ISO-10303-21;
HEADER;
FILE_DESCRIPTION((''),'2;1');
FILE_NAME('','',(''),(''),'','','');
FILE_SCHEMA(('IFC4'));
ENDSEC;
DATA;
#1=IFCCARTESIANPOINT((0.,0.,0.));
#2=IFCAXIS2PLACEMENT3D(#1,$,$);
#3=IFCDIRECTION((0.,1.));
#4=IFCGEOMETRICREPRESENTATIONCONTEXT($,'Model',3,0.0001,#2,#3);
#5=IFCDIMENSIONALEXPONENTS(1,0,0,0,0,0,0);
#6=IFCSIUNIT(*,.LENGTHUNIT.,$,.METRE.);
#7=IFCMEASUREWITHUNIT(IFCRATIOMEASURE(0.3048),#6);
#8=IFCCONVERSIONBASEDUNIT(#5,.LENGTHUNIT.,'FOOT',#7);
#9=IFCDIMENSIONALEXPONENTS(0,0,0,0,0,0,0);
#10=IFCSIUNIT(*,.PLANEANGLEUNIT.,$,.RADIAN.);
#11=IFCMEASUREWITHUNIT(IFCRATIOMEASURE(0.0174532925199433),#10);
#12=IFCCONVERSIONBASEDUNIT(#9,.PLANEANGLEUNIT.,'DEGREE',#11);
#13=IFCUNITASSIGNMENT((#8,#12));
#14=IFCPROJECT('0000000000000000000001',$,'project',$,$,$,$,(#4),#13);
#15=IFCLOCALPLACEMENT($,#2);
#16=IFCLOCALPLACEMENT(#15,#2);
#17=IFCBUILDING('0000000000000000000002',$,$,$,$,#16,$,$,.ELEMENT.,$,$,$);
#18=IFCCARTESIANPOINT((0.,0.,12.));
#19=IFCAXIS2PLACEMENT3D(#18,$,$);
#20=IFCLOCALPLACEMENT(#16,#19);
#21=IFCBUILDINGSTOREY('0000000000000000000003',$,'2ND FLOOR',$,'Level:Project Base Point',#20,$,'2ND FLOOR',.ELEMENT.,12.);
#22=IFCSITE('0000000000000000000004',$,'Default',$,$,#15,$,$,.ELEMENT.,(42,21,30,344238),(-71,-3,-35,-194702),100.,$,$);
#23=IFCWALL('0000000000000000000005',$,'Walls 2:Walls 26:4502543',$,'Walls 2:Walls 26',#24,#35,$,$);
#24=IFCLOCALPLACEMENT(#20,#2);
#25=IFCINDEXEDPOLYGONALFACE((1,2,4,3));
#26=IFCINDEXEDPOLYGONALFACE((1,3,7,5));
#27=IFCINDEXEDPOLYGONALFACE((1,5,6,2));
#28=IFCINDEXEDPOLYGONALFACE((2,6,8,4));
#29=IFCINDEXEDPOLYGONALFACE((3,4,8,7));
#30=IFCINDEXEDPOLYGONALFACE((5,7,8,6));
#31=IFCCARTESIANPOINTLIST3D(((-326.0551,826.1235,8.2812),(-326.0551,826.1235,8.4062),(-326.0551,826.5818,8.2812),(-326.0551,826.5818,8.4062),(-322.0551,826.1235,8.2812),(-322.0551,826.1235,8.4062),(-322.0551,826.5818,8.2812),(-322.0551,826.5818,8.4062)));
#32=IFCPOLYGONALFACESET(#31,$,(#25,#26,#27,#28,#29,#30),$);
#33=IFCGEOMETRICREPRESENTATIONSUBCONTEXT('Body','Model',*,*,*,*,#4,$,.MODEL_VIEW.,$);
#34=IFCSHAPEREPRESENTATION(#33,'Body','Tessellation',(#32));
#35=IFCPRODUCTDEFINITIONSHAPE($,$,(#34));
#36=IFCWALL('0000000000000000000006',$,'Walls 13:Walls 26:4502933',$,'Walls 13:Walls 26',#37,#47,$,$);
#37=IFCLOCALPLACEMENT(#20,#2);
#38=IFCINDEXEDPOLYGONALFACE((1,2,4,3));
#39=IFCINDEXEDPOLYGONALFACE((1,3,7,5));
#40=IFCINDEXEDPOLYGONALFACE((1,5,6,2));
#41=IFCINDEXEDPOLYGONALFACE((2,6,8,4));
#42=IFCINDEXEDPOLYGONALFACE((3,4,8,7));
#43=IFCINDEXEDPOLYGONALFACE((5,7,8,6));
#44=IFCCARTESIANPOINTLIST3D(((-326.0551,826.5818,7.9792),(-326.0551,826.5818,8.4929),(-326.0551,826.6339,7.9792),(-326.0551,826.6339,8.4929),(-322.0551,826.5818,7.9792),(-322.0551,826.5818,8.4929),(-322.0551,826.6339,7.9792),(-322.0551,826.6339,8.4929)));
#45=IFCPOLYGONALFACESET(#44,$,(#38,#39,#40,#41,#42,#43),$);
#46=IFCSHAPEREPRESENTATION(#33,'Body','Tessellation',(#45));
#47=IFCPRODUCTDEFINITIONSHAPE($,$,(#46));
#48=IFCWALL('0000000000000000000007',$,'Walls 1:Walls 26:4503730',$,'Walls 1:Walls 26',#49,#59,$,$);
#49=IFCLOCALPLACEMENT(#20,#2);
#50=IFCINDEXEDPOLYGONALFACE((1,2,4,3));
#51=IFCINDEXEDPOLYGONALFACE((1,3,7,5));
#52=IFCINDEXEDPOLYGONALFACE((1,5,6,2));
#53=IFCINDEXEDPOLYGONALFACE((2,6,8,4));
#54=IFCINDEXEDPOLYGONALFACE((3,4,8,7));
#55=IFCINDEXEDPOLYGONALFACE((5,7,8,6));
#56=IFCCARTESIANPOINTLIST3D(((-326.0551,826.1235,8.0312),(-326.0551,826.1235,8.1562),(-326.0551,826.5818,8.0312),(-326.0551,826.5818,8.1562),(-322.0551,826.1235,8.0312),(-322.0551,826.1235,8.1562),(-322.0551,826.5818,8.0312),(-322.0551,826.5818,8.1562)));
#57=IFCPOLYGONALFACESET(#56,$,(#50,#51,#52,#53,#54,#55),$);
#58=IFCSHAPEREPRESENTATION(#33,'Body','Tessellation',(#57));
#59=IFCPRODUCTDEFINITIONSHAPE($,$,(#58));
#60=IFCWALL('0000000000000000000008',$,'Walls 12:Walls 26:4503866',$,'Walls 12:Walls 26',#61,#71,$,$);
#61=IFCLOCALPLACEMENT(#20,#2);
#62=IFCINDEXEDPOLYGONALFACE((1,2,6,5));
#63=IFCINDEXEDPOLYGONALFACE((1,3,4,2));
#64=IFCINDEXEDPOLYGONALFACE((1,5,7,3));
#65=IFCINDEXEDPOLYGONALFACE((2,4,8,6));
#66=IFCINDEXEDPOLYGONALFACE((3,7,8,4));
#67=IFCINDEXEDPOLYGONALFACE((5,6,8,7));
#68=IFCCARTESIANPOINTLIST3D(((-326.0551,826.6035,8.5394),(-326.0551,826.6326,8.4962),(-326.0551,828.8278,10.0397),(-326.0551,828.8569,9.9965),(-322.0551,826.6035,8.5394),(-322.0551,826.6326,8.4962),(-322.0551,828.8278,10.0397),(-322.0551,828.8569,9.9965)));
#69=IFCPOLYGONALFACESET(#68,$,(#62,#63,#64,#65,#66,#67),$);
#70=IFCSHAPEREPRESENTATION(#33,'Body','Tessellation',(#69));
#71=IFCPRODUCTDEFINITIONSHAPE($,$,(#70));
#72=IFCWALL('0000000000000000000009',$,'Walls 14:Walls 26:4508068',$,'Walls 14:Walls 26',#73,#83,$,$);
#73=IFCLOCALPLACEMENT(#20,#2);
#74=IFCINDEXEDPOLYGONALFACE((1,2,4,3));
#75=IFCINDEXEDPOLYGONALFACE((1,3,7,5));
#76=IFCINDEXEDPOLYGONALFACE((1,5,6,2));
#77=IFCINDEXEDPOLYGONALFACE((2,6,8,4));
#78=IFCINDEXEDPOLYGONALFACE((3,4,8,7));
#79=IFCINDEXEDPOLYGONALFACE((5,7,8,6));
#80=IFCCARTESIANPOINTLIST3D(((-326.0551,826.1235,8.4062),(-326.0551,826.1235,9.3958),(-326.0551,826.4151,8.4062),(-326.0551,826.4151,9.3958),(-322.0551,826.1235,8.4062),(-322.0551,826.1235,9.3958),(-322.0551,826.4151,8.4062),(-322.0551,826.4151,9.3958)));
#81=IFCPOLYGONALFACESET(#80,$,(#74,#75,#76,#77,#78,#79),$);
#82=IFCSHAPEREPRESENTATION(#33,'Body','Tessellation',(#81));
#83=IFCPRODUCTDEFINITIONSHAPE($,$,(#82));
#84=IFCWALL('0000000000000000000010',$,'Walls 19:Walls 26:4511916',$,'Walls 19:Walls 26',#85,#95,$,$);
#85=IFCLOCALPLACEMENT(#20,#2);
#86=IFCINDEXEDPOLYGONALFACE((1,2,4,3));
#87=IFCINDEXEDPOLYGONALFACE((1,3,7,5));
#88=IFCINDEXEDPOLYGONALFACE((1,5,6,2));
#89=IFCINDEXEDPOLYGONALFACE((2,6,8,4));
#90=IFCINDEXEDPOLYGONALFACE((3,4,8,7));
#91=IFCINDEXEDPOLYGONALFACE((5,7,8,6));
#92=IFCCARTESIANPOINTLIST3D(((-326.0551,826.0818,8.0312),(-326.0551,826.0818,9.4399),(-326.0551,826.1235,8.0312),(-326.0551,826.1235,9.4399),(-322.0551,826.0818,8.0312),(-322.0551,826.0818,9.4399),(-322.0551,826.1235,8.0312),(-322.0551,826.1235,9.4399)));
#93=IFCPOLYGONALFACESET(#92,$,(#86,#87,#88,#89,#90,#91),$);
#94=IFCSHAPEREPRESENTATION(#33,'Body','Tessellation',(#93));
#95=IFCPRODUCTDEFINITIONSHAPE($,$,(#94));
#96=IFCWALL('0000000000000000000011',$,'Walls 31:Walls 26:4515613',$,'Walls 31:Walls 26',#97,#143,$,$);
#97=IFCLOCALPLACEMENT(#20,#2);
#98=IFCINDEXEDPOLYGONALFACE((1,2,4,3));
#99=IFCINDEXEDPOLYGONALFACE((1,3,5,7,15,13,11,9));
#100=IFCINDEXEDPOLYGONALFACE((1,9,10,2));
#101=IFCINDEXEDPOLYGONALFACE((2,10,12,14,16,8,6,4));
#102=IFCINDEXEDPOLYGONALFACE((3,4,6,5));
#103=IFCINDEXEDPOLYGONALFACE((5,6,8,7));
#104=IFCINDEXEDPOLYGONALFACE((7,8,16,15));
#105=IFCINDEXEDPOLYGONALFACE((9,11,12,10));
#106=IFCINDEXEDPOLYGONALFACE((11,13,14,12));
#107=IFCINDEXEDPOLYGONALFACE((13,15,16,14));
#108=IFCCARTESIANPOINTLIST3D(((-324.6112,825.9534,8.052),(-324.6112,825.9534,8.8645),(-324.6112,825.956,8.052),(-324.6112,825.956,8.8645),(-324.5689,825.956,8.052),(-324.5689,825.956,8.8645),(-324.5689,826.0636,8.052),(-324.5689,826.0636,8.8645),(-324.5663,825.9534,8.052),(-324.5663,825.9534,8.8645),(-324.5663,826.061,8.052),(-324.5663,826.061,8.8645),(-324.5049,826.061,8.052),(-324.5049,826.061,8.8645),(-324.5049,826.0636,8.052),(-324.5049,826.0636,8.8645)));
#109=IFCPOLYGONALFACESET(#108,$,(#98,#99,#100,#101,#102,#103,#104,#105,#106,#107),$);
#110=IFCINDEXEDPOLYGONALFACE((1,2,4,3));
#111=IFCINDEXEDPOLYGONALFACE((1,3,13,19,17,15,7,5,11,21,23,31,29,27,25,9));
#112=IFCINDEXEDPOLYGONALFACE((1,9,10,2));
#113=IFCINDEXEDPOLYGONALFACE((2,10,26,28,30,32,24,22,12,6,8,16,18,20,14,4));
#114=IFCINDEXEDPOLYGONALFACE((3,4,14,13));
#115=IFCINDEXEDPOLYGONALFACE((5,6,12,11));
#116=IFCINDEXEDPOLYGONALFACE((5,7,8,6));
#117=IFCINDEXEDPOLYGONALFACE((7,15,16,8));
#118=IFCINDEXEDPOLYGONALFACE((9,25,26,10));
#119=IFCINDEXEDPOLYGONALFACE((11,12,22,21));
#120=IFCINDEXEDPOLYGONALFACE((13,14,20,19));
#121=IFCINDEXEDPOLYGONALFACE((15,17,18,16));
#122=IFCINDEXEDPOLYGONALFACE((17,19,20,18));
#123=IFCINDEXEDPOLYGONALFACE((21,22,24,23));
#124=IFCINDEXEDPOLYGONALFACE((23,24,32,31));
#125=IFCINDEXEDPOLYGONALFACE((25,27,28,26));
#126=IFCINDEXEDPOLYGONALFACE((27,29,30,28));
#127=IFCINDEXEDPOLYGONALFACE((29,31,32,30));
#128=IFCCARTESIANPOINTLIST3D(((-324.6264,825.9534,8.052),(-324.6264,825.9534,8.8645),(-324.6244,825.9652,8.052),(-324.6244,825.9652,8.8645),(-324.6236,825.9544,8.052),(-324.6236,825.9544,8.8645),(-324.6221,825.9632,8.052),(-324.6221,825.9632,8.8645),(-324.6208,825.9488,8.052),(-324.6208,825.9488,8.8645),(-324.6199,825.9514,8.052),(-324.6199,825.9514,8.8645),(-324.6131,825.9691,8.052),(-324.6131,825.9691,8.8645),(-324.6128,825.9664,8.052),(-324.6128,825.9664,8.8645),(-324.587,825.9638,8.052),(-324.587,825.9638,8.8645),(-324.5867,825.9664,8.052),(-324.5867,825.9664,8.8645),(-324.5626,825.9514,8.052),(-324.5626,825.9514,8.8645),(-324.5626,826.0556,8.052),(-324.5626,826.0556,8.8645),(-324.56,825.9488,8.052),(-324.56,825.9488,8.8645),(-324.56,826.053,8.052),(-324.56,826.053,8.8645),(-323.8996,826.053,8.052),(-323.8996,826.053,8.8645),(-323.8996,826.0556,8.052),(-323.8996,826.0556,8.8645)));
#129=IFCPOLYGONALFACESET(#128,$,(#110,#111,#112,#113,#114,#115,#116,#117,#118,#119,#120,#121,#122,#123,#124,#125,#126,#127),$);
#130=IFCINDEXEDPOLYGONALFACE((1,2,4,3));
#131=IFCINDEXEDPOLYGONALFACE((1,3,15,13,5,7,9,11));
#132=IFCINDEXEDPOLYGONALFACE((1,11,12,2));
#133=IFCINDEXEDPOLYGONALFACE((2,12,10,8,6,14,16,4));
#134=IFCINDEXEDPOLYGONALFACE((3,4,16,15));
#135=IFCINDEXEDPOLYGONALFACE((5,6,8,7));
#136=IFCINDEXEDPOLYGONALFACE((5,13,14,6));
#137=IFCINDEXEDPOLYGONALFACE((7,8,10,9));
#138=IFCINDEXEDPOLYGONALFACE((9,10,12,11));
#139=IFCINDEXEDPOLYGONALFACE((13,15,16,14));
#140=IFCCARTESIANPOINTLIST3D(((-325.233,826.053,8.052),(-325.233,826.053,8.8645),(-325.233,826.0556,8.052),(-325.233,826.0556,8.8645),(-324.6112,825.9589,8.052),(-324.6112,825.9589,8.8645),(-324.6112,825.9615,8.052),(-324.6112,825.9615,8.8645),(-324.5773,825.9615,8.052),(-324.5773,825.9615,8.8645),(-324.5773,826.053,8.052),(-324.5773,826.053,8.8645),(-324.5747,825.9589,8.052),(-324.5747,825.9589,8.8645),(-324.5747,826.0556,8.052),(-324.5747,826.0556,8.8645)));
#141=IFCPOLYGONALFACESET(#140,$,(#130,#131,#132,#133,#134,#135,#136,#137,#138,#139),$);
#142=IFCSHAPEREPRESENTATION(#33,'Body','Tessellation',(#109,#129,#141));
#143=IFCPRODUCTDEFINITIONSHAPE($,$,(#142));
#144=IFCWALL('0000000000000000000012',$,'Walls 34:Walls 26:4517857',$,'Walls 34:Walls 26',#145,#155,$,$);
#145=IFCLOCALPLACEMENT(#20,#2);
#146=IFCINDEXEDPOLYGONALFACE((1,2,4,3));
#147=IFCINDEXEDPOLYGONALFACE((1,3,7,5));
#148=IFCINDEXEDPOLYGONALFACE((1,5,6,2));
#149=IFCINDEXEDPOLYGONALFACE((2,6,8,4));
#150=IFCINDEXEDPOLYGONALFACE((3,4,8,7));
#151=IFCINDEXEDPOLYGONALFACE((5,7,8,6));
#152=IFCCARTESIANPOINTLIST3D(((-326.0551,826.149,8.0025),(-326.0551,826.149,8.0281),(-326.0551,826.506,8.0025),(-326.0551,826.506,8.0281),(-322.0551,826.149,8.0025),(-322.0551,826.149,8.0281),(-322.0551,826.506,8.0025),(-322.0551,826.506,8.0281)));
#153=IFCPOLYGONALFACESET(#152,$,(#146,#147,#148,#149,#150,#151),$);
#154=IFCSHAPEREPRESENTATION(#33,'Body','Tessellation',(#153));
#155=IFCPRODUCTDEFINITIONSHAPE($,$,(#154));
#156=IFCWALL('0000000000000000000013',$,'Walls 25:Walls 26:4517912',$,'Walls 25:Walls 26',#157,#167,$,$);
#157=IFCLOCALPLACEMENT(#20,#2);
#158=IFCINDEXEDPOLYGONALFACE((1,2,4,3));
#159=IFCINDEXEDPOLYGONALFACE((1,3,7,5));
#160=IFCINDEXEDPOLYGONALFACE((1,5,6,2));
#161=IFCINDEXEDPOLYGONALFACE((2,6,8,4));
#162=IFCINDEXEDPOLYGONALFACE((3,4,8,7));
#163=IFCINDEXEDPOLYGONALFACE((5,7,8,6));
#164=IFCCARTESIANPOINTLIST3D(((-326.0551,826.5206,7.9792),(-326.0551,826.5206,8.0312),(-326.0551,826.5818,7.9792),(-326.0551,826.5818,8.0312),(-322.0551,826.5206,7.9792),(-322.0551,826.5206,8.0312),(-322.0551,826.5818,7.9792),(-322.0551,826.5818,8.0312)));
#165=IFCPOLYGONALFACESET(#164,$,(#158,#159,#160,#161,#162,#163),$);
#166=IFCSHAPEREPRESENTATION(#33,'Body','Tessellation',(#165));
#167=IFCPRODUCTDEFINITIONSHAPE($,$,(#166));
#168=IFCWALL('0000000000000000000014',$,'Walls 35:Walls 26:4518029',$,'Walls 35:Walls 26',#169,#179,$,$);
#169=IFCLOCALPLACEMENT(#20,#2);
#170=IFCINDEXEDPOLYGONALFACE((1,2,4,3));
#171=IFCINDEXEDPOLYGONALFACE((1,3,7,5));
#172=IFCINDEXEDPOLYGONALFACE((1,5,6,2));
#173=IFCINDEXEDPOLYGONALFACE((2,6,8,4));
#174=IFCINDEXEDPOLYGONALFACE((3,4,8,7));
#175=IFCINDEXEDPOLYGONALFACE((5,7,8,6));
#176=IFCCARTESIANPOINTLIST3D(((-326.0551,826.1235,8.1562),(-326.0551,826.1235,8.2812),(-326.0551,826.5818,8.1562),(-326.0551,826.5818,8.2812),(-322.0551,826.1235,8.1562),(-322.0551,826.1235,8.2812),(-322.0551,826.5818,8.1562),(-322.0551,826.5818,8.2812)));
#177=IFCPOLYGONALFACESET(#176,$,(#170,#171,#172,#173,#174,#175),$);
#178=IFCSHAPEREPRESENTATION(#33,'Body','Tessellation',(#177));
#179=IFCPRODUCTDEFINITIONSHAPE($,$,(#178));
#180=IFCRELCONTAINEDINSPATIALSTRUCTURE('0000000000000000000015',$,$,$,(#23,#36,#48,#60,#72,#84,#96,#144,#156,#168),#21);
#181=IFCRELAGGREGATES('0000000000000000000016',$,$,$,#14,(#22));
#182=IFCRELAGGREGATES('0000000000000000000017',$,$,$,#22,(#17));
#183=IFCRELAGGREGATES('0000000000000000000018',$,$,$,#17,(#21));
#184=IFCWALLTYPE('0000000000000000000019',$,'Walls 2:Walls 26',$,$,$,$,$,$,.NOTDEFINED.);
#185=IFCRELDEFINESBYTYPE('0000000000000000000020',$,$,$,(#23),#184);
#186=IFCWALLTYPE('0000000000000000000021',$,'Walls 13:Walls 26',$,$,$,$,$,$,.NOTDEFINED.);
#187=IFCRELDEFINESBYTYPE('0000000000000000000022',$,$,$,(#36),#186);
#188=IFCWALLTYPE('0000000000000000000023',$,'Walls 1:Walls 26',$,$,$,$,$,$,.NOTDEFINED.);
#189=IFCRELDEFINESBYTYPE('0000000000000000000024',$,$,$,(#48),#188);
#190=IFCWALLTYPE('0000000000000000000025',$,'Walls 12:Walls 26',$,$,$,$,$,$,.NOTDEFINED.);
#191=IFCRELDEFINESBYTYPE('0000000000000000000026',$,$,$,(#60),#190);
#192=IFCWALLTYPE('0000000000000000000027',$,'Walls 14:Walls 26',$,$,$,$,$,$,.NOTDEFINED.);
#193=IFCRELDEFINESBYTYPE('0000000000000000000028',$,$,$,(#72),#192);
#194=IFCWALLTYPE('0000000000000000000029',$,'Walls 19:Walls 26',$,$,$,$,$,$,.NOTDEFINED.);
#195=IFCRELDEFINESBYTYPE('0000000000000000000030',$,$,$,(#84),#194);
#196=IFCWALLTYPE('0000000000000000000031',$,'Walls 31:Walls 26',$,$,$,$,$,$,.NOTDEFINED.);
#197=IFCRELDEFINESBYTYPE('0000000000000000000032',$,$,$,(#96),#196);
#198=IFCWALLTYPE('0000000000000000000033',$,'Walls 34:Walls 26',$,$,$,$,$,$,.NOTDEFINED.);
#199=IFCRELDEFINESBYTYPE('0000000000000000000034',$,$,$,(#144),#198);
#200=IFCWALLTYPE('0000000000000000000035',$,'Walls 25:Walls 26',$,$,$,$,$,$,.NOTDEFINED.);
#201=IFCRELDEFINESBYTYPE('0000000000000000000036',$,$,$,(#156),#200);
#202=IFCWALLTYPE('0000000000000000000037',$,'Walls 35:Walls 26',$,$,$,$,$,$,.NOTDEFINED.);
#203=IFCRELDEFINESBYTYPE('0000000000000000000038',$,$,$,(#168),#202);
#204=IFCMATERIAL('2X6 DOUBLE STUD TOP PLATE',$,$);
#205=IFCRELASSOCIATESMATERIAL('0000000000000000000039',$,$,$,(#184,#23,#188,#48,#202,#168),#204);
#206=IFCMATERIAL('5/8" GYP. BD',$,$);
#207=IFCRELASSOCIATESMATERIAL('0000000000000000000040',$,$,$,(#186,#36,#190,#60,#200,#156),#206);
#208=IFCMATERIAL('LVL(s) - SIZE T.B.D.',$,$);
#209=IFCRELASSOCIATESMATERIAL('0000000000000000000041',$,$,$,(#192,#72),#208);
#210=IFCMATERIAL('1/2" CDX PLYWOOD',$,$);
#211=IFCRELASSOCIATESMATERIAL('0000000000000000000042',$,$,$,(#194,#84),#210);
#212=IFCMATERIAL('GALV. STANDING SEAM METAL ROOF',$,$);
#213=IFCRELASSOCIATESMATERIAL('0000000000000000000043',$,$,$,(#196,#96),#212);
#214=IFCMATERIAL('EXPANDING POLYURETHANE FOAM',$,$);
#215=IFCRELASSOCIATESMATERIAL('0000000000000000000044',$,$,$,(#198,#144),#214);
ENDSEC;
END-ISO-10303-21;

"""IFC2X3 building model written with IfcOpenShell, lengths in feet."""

from ifc_helpers import new_model, entity, si_unit, converted_unit, direction, frame, frame_2d, origin, origin_2d_with_axis, place, context, subcontext, project, spatial, polyline, rectangle, outline, extrude, material, type_object, element, save


model = new_model("IFC2X3")

# Units and contexts
model_context = context("Model", 3, precision=0.0001, world=origin(), true_north=direction((0.0, 1.0)))
body_context = subcontext(model_context, "Body", "Model", "MODEL_VIEW")
ifc_project = project(units=[converted_unit("LENGTHUNIT", "FOOT", entity("IfcRatioMeasure", 0.3048), si_unit("LENGTHUNIT", "METRE"), dimensions=[1, 0, 0, 0, 0, 0, 0]), converted_unit("PLANEANGLEUNIT", "DEGREE", entity("IfcRatioMeasure", 0.0174532925199433), si_unit("PLANEANGLEUNIT", "RADIAN"), dimensions=[0, 0, 0, 0, 0, 0, 0])], contexts=[model_context])

# Site, building, storey
site_placement = place(None, origin())
site = spatial("IfcSite", under=ifc_project, at=site_placement, Name="Default", CompositionType="ELEMENT", RefLatitude=(42, 21, 30, 344238), RefLongitude=(-71, -3, -35, -194702), RefElevation=100.0)
building_placement = place(site_placement, origin())
building = spatial("IfcBuilding", under=site, at=building_placement, CompositionType="ELEMENT")
storey_placement = place(building_placement, frame((0.0, 0.0, 12.0)))
storey = spatial("IfcBuildingStorey", under=building, at=storey_placement, Name="2ND FLOOR", ObjectType="Level:Project Base Point", LongName="2ND FLOOR", CompositionType="ELEMENT", Elevation=12.0)

# Walls
ifc_material_1 = material(Name="2X6 DOUBLE STUD TOP PLATE")
wall_type_1 = type_object("IfcWallType", Name="Walls 2:Walls 26", PredefinedType="NOTDEFINED", material=ifc_material_1)
wall_1_placement = place(storey_placement, frame((-326.0551, 826.1235, 8.2812)))
element("IfcWall", 1, at=wall_1_placement, inside=storey, type_object=wall_type_1, material=ifc_material_1, Name="Walls 2:Walls 26:4502543", ObjectType="Walls 2:Walls 26", context=body_context, shape_type="SweptSolid", body=[
    extrude(rectangle(XDim=4.0, YDim=0.4583, at=frame_2d((0.0, 0.0), x_axis=(1.0, 0.0))), frame((2.0, 0.2292, 0.0), z_axis=(0.0, 0.0, 1.0), x_axis=(-1.0, 0.0, 0.0)), (0.0, 0.0, 1.0), 0.125),
])
ifc_material_2 = material(Name="5/8\" GYP. BD")
wall_type_2 = type_object("IfcWallType", Name="Walls 13:Walls 26", PredefinedType="NOTDEFINED", material=ifc_material_2)
wall_2_placement = place(storey_placement, frame((-326.0551, 826.5818, 7.9792)))
element("IfcWall", 2, at=wall_2_placement, inside=storey, type_object=wall_type_2, material=ifc_material_2, Name="Walls 13:Walls 26:4502933", ObjectType="Walls 13:Walls 26", context=body_context, shape_type="SweptSolid", body=[
    extrude(rectangle(XDim=4.0, YDim=0.0521, at=frame_2d((0.0, 0.0), x_axis=(1.0, 0.0))), frame((2.0, 0.026, 0.0), z_axis=(0.0, 0.0, 1.0), x_axis=(-1.0, 0.0, 0.0)), (0.0, 0.0, 1.0), 0.5137),
])
wall_type_3 = type_object("IfcWallType", Name="Walls 1:Walls 26", PredefinedType="NOTDEFINED", material=ifc_material_1)
wall_3_placement = place(storey_placement, frame((-326.0551, 826.1235, 8.0312)))
element("IfcWall", 3, at=wall_3_placement, inside=storey, type_object=wall_type_3, material=ifc_material_1, Name="Walls 1:Walls 26:4503730", ObjectType="Walls 1:Walls 26", context=body_context, shape_type="SweptSolid", body=[
    extrude(rectangle(XDim=4.0, YDim=0.4583, at=frame_2d((0.0, 0.0), x_axis=(1.0, 0.0))), frame((2.0, 0.2292, 0.0), z_axis=(0.0, 0.0, 1.0), x_axis=(-1.0, 0.0, 0.0)), (0.0, 0.0, 1.0), 0.125),
])
wall_type_4 = type_object("IfcWallType", Name="Walls 12:Walls 26", PredefinedType="NOTDEFINED", material=ifc_material_2)
wall_4_placement = place(storey_placement, frame((-326.0551, 826.6035, 8.4962)))
element("IfcWall", 4, at=wall_4_placement, inside=storey, type_object=wall_type_4, material=ifc_material_2, Name="Walls 12:Walls 26:4503866", ObjectType="Walls 12:Walls 26", context=body_context, shape_type="SweptSolid", body=[
    extrude(rectangle(XDim=2.683, YDim=4.0, at=frame_2d((0.0, 0.0), x_axis=(0.0, 1.0))), frame((2.0, 1.1413, 0.7501), z_axis=(0.0, -0.559193, 0.829038), x_axis=(-1.0, 0.0, 0.0)), (0.0, 0.0, 1.0), 0.0521),
])
ifc_material_3 = material(Name="LVL(s) - SIZE T.B.D.")
wall_type_5 = type_object("IfcWallType", Name="Walls 14:Walls 26", PredefinedType="NOTDEFINED", material=ifc_material_3)
wall_5_placement = place(storey_placement, frame((-326.0551, 826.1235, 8.4062)))
element("IfcWall", 5, at=wall_5_placement, inside=storey, type_object=wall_type_5, material=ifc_material_3, Name="Walls 14:Walls 26:4508068", ObjectType="Walls 14:Walls 26", context=body_context, shape_type="SweptSolid", body=[
    extrude(rectangle(XDim=4.0, YDim=0.2917, at=origin_2d_with_axis()), frame((2.0, 0.1458, 0.0), z_axis=(0.0, 0.0, 1.0), x_axis=(-1.0, 0.0, 0.0)), (0.0, 0.0, 1.0), 0.9896),
])
ifc_material_4 = material(Name="1/2\" CDX PLYWOOD")
wall_type_6 = type_object("IfcWallType", Name="Walls 19:Walls 26", PredefinedType="NOTDEFINED", material=ifc_material_4)
wall_6_placement = place(storey_placement, frame((-326.0551, 826.0818, 8.0312)))
element("IfcWall", 6, at=wall_6_placement, inside=storey, type_object=wall_type_6, material=ifc_material_4, Name="Walls 19:Walls 26:4511916", ObjectType="Walls 19:Walls 26", context=body_context, shape_type="SweptSolid", body=[
    extrude(rectangle(XDim=4.0, YDim=0.0417, at=frame_2d((0.0, 0.0), x_axis=(1.0, 0.0))), frame((2.0, 0.0208, 0.0), z_axis=(0.0, 0.0, 1.0), x_axis=(-1.0, 0.0, 0.0)), (0.0, 0.0, 1.0), 1.4087),
])
ifc_material_5 = material(Name="GALV. STANDING SEAM METAL ROOF")
wall_type_7 = type_object("IfcWallType", Name="Walls 31:Walls 26", PredefinedType="NOTDEFINED", material=ifc_material_5)
wall_7_placement = place(storey_placement, frame((-325.233, 825.9488, 8.052)))
element("IfcWall", 7, at=wall_7_placement, inside=storey, type_object=wall_type_7, material=ifc_material_5, Name="Walls 31:Walls 26:4515613", ObjectType="Walls 31:Walls 26", context=body_context, shape_type="SweptSolid", body=[
    extrude(outline(polyline([(-0.0551, 0.0061), (-0.0551, -0.0579), (-0.0525, -0.0579), (-0.0525, 0.0035), (0.0551, 0.0035), (0.0551, 0.0484), (0.0525, 0.0484), (0.0525, 0.0061), (-0.0551, 0.0061)])), frame((0.6702, 0.0597, 0.0), z_axis=(0.0, 0.0, -1.0), x_axis=(0.0, -1.0, 0.0)), (0.0, 0.0, -1.0), 0.8125),
    extrude(outline(polyline([(-0.0471, -0.1057), (-0.0495, -0.1015), (-0.0395, -0.0451), (0.0631, -0.0632), (0.1784, 0.5896), (0.1759, 0.5901), (0.061, -0.0602), (-0.0416, -0.0421), (-0.0522, -0.102), (-0.0487, -0.1083), (-0.0367, -0.1083), (-0.0309, -0.0979), (-0.029, -0.0715), (-0.0316, -0.0713), (-0.0334, -0.0971), (-0.0382, -0.1057), (-0.0471, -0.1057)])), frame((0.7217, 0.0337, 0.0), z_axis=(0.0, 0.0, -1.0), x_axis=(0.174018, 0.984742, 0.0)), (0.0, 0.0, -1.0), 0.8125),
    extrude(outline(polyline([(-0.1743, -0.0483), (0.4839, -0.0483), (0.4839, -0.0457), (-0.1717, -0.0457), (-0.1717, 0.0457), (-0.1379, 0.0457), (-0.1379, 0.0483), (-0.1743, 0.0483), (-0.1743, -0.0483)])), frame((0.4839, 0.0585, 0.0), z_axis=(0.0, 0.0, 1.0), x_axis=(-1.0, 0.0, 0.0)), (0.0, 0.0, 1.0), 0.8125),
])
ifc_material_6 = material(Name="EXPANDING POLYURETHANE FOAM")
wall_type_8 = type_object("IfcWallType", Name="Walls 34:Walls 26", PredefinedType="NOTDEFINED", material=ifc_material_6)
wall_8_placement = place(storey_placement, frame((-326.0551, 826.149, 8.0025)))
element("IfcWall", 8, at=wall_8_placement, inside=storey, type_object=wall_type_8, material=ifc_material_6, Name="Walls 34:Walls 26:4517857", ObjectType="Walls 34:Walls 26", context=body_context, shape_type="SweptSolid", body=[
    extrude(rectangle(XDim=4.0, YDim=0.357, at=origin_2d_with_axis()), frame((2.0, 0.1785, 0.0), z_axis=(0.0, 0.0, 1.0), x_axis=(-1.0, 0.0, 0.0)), (0.0, 0.0, 1.0), 0.0256),
])
wall_type_9 = type_object("IfcWallType", Name="Walls 25:Walls 26", PredefinedType="NOTDEFINED", material=ifc_material_2)
wall_9_placement = place(storey_placement, frame((-326.0551, 826.5206, 7.9792)))
element("IfcWall", 9, at=wall_9_placement, inside=storey, type_object=wall_type_9, material=ifc_material_2, Name="Walls 25:Walls 26:4517912", ObjectType="Walls 25:Walls 26", context=body_context, shape_type="SweptSolid", body=[
    extrude(rectangle(XDim=4.0, YDim=0.0611, at=origin_2d_with_axis()), frame((2.0, 0.0306, 0.0), z_axis=(0.0, 0.0, 1.0), x_axis=(-1.0, 0.0, 0.0)), (0.0, 0.0, 1.0), 0.0521),
])
wall_type_10 = type_object("IfcWallType", Name="Walls 35:Walls 26", PredefinedType="NOTDEFINED", material=ifc_material_1)
wall_10_placement = place(storey_placement, frame((-326.0551, 826.1235, 8.1562)))
element("IfcWall", 10, at=wall_10_placement, inside=storey, type_object=wall_type_10, material=ifc_material_1, Name="Walls 35:Walls 26:4518029", ObjectType="Walls 35:Walls 26", context=body_context, shape_type="SweptSolid", body=[
    extrude(rectangle(XDim=4.0, YDim=0.4583, at=frame_2d((0.0, 0.0), x_axis=(1.0, 0.0))), frame((2.0, 0.2292, 0.0), z_axis=(0.0, 0.0, 1.0), x_axis=(-1.0, 0.0, 0.0)), (0.0, 0.0, 1.0), 0.125),
])

save(model, "model.ifc")
